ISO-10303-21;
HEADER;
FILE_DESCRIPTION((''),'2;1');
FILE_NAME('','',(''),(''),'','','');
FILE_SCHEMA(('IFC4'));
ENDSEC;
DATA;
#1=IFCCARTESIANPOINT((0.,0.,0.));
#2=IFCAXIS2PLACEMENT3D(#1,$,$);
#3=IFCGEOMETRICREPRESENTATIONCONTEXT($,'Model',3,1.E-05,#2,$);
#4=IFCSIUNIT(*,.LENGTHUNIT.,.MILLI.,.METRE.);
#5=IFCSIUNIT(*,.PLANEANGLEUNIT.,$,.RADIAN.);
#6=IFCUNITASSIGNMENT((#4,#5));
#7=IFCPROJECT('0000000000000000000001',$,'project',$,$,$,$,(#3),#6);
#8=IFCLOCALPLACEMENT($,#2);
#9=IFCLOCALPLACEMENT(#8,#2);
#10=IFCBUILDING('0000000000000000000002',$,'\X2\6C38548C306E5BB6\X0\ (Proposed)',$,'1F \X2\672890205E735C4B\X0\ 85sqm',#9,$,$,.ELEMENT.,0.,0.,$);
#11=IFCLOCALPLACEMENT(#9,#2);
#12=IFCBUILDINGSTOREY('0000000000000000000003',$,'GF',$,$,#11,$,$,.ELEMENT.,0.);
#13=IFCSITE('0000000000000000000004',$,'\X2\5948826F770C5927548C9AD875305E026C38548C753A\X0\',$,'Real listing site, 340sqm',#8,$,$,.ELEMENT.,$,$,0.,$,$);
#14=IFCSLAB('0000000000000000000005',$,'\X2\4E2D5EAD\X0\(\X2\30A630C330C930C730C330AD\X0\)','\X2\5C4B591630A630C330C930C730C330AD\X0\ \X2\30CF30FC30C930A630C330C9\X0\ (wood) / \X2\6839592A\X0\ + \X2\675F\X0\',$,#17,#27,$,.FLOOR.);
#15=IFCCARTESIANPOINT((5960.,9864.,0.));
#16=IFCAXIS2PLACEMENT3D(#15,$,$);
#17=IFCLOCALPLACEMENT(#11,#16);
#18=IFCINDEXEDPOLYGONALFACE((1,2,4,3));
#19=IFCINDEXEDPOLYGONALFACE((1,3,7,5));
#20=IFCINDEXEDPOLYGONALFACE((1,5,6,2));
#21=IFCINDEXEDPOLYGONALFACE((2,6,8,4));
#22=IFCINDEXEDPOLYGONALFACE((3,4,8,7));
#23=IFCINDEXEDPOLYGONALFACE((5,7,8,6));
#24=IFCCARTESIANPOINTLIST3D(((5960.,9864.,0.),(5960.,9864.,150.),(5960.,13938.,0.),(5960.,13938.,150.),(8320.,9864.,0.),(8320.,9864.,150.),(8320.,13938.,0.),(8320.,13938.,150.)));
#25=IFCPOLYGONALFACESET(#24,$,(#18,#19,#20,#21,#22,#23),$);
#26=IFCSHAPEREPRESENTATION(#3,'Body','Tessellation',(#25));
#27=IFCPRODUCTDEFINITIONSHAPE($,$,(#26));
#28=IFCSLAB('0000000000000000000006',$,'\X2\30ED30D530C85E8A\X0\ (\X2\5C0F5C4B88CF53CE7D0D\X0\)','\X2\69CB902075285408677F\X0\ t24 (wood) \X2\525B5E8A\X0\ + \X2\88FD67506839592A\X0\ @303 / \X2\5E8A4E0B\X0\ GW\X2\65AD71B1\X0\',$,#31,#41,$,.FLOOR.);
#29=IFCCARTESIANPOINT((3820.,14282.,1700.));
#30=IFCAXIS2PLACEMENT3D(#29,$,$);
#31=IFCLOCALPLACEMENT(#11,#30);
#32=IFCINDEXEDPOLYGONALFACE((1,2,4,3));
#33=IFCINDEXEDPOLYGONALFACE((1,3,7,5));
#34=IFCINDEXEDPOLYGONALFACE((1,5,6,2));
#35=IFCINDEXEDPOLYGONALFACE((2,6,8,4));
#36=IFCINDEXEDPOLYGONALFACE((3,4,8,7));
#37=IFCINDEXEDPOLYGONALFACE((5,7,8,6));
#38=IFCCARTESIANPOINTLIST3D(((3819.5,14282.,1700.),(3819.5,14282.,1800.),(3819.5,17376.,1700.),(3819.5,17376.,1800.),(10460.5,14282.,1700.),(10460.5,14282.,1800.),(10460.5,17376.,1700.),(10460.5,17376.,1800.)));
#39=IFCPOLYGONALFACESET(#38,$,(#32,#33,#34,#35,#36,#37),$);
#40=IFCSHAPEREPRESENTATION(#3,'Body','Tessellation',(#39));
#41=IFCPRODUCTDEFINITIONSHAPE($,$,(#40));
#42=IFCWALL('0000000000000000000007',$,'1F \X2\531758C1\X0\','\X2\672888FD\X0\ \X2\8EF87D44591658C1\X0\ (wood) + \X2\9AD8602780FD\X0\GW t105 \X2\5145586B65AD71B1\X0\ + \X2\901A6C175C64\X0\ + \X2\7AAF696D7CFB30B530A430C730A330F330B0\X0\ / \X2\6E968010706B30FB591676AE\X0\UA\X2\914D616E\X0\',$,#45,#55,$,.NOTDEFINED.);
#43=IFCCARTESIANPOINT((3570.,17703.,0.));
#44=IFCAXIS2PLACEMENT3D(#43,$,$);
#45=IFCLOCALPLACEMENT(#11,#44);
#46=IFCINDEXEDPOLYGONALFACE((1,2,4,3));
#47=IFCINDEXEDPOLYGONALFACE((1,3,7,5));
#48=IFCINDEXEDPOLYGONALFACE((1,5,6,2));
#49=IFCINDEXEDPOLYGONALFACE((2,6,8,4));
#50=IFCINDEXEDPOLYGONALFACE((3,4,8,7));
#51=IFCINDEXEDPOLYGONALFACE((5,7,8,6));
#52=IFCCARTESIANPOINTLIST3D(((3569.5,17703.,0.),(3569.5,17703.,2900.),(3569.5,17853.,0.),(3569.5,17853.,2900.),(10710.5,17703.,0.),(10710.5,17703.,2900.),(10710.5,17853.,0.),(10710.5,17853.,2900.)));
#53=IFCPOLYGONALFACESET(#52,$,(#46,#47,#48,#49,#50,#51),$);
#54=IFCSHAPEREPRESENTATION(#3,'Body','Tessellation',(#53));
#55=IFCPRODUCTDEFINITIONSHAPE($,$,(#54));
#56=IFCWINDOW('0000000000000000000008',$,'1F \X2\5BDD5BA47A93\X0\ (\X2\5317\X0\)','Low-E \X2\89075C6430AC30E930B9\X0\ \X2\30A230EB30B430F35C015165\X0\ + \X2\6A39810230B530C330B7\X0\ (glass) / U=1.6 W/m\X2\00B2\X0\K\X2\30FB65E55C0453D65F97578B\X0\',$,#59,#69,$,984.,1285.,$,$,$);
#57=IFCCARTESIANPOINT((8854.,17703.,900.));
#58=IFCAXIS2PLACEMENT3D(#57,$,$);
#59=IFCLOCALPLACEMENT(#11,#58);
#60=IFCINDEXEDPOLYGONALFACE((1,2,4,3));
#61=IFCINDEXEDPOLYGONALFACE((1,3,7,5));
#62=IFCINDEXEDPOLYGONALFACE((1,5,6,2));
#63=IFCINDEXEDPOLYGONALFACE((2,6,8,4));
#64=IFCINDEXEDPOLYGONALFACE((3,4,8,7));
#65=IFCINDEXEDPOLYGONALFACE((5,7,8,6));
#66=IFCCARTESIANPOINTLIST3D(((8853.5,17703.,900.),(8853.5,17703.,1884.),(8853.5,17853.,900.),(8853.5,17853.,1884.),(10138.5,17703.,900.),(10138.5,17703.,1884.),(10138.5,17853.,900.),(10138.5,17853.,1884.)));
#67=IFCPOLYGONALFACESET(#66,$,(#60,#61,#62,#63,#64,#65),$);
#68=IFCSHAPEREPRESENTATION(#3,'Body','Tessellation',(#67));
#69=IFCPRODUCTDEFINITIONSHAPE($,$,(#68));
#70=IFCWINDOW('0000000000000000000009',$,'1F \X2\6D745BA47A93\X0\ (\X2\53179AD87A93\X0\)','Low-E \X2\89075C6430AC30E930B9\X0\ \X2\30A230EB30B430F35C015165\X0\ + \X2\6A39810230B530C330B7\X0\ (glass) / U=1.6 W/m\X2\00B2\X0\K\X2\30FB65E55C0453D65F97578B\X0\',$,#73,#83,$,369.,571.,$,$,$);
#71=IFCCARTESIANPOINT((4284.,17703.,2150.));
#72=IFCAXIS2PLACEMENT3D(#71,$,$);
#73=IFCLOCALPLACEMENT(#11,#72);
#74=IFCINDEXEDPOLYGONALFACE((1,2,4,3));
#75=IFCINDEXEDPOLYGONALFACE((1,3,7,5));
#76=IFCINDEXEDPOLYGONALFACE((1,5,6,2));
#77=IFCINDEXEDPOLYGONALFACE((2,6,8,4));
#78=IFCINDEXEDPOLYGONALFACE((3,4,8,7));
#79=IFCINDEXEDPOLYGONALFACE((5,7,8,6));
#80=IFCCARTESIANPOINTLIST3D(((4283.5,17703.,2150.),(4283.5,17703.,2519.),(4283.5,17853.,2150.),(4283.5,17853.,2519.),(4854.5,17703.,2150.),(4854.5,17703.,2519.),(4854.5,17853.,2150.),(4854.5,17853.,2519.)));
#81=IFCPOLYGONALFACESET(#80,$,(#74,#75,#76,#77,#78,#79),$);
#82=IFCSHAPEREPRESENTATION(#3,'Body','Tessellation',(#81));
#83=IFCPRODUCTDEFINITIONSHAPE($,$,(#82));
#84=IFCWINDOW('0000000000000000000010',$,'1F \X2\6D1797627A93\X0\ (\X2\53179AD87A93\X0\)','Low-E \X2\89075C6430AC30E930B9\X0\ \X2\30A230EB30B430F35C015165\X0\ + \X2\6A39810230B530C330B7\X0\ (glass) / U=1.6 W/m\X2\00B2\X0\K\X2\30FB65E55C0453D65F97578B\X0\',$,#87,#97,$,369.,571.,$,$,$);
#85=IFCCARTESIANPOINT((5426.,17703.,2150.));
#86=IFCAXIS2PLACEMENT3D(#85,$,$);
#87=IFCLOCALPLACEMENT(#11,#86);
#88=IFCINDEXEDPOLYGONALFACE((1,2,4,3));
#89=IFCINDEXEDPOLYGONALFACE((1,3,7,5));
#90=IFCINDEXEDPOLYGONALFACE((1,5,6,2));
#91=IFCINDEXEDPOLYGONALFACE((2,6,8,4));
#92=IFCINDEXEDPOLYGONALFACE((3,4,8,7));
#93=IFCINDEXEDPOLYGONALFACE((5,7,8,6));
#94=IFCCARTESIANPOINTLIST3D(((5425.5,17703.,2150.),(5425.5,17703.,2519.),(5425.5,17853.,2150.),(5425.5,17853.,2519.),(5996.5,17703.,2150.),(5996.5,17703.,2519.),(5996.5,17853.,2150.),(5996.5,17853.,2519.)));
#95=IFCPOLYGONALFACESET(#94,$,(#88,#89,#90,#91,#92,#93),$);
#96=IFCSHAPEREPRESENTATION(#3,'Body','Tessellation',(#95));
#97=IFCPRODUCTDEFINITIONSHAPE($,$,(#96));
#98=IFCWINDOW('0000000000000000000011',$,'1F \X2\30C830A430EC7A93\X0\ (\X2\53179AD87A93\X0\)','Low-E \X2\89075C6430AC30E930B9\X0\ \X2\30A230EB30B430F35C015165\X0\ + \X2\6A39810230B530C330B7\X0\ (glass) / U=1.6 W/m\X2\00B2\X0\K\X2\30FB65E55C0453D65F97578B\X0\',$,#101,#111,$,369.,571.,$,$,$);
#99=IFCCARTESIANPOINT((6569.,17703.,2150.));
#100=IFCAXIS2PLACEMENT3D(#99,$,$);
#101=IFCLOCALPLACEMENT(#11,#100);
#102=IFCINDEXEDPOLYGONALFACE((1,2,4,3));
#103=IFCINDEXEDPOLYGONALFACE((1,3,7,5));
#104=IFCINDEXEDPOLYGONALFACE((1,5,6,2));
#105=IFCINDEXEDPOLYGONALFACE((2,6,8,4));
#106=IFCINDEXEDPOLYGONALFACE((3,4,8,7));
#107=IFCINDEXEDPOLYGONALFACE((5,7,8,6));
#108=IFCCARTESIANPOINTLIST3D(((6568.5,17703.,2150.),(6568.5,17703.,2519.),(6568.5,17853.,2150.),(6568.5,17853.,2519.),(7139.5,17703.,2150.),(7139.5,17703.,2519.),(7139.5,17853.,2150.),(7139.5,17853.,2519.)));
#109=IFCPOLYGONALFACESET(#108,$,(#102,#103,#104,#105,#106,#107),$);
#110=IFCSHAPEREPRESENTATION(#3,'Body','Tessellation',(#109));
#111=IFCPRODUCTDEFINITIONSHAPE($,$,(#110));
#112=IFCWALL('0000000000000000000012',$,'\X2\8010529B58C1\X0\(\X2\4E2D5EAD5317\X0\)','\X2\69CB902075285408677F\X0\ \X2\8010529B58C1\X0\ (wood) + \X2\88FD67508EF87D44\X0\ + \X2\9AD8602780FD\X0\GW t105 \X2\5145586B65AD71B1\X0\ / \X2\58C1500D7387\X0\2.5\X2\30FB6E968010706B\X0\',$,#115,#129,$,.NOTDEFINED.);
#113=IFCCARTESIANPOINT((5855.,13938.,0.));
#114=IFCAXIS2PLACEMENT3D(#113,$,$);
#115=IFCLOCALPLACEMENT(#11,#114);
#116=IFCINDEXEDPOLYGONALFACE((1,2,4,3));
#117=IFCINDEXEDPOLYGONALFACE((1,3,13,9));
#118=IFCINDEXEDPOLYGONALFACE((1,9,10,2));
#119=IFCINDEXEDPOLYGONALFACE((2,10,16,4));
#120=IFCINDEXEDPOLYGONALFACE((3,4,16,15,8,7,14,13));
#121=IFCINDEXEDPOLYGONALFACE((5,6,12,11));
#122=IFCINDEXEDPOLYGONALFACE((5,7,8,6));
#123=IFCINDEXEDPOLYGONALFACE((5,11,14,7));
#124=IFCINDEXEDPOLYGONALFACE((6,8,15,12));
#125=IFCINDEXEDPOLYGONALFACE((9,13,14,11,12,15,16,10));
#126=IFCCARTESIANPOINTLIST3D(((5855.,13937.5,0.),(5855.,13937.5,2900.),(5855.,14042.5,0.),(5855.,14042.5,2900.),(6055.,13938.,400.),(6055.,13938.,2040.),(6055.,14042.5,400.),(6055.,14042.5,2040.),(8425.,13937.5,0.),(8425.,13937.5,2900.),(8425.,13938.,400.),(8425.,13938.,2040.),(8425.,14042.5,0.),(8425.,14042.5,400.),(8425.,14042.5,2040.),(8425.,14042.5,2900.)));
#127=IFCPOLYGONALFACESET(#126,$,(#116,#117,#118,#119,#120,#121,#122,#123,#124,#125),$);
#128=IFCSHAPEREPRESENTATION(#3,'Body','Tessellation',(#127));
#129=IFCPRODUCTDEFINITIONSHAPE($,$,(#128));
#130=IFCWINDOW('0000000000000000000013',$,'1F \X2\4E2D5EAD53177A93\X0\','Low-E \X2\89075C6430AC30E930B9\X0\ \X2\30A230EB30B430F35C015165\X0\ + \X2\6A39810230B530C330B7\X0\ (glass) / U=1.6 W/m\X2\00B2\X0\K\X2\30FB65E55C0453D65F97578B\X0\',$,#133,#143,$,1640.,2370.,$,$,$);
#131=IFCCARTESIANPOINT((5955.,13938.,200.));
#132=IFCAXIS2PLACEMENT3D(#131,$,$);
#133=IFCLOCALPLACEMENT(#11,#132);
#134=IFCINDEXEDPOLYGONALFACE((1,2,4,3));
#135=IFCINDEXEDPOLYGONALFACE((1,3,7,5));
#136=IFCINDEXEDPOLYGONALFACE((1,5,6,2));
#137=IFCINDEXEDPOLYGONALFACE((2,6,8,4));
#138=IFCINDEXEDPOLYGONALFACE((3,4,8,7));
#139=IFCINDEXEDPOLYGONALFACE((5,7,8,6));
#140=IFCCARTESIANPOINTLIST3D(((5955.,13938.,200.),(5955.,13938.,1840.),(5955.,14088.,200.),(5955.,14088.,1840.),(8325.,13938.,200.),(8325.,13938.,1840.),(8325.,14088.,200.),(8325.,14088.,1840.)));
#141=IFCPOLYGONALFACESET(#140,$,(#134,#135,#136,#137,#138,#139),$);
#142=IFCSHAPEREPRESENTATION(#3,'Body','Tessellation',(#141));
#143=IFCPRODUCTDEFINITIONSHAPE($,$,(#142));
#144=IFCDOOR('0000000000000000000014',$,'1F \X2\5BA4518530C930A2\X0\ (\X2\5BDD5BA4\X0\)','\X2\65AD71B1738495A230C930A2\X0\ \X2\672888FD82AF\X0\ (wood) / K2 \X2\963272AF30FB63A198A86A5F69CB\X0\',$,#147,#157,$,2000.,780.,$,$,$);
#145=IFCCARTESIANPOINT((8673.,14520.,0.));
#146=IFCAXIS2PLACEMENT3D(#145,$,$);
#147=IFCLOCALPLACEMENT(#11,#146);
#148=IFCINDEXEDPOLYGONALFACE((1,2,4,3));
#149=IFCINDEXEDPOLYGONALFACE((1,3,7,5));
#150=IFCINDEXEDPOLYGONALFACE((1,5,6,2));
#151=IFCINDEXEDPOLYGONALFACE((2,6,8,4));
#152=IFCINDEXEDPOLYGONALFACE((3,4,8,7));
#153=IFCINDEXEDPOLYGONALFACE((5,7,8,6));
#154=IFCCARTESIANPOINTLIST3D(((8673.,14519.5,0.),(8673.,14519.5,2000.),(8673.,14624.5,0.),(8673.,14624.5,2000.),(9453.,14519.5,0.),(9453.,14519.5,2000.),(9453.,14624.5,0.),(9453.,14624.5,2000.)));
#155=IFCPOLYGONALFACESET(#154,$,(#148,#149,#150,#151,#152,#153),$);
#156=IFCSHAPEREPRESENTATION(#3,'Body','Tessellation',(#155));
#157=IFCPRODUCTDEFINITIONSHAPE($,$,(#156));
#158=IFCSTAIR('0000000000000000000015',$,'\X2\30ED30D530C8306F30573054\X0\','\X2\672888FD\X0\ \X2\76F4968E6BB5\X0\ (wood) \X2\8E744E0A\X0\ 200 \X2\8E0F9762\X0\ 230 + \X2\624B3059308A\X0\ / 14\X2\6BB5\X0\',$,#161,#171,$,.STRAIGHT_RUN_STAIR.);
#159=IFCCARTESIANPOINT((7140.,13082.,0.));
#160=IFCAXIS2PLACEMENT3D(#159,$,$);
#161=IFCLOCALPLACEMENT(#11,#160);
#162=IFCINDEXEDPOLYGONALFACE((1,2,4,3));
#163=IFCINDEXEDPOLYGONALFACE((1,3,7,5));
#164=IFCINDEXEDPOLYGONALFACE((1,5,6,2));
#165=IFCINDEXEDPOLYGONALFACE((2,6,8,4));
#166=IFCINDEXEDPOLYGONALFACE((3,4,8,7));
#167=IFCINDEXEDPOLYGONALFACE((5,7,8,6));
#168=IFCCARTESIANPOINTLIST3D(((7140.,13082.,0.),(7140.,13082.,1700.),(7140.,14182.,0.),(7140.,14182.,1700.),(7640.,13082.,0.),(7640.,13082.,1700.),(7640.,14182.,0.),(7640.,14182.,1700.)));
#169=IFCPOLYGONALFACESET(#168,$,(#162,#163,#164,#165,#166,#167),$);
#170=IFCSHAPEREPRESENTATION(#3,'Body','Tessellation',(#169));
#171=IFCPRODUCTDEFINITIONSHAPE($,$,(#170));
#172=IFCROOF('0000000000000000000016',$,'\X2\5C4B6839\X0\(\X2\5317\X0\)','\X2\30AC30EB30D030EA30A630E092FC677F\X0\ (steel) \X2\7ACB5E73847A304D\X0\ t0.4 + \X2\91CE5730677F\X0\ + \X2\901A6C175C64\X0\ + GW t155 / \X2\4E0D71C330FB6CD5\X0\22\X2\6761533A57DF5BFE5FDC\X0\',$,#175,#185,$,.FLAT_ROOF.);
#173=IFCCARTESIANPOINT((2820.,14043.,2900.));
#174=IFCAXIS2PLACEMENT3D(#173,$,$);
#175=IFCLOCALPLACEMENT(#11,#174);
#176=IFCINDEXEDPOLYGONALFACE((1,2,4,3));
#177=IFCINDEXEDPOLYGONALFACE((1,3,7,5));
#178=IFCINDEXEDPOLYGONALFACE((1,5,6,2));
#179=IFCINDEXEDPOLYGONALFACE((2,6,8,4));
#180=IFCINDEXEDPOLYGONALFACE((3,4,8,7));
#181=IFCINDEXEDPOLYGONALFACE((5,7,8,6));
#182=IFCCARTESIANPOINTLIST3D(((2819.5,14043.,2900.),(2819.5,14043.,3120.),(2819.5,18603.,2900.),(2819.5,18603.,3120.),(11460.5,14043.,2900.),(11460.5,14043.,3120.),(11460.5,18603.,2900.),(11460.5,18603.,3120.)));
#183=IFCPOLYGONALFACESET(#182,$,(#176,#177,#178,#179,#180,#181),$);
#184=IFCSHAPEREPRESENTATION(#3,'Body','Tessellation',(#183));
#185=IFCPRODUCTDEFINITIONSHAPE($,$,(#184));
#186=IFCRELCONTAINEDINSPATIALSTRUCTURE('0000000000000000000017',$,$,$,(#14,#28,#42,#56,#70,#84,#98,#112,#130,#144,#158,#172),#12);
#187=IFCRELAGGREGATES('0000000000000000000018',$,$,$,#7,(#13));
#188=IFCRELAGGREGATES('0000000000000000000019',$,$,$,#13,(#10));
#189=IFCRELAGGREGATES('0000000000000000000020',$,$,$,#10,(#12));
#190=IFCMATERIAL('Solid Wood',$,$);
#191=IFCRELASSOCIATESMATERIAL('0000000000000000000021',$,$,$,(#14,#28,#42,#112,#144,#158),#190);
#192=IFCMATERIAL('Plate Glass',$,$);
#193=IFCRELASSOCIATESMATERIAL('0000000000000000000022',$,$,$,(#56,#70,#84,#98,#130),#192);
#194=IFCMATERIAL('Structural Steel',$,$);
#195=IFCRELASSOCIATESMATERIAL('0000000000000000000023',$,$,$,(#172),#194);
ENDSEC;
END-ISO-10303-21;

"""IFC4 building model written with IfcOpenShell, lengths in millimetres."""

from ifc_helpers import new_model, si_unit, frame, frame_2d, origin, place, context, project, spatial, rectangle, extrude, material, element, fill, save


model = new_model("IFC4")

# Units and contexts
model_context = context("Model", 3, precision=1e-05, world=origin())
ifc_project = project(units=[si_unit("LENGTHUNIT", "METRE", prefix="MILLI"), si_unit("PLANEANGLEUNIT", "RADIAN")], contexts=[model_context])

# Site, building, storey
site_placement = place(None, origin())
site = spatial("IfcSite", under=ifc_project, at=site_placement, Name="奈良県大和高田市永和町", ObjectType="Real listing site, 340sqm", CompositionType="ELEMENT", RefElevation=0.0)
building_placement = place(site_placement, origin())
building = spatial("IfcBuilding", under=site, at=building_placement, Name="永和の家 (Proposed)", ObjectType="1F 木造平屋 85sqm", CompositionType="ELEMENT", ElevationOfRefHeight=0.0, ElevationOfTerrain=0.0)
storey_placement = place(building_placement, origin())
storey = spatial("IfcBuildingStorey", under=building, at=storey_placement, Name="GF", CompositionType="ELEMENT", Elevation=0.0)

# Slabs
ifc_material_1 = material(Name="Solid Wood")
slab_1_placement = place(storey_placement, frame((5960.0, 9864.0, 0.0)))
element("IfcSlab", 1, at=slab_1_placement, inside=storey, material=ifc_material_1, Name="中庭(ウッドデッキ)", Description="屋外ウッドデッキ ハードウッド (wood) / 根太 + 束", PredefinedType="FLOOR", context=model_context, shape_type="SweptSolid", body=[
    extrude(rectangle(XDim=2360.0, YDim=4074.0, at=frame_2d((1180.0, 2037.0))), frame((5960.0, 9864.0, 0.0)), (0.0, 0.0, 1.0), 150.0),
])
slab_2_placement = place(storey_placement, frame((3820.0, 14282.0, 1700.0)))
element("IfcSlab", 2, at=slab_2_placement, inside=storey, material=ifc_material_1, Name="ロフト床 (小屋裏収納)", Description="構造用合板 t24 (wood) 剛床 + 製材根太 @303 / 床下 GW断熱", PredefinedType="FLOOR", context=model_context, shape_type="SweptSolid", body=[
    extrude(rectangle(XDim=6641.0, YDim=3094.0, at=frame_2d((3320.0, 1547.0))), frame((3820.0, 14282.0, 1700.0)), (0.0, 0.0, 1.0), 100.0),
])

# Wall, openings, windows
wall_1_placement = place(storey_placement, frame((3570.0, 17703.0, 0.0)))
wall_1 = element("IfcWall", 3, at=wall_1_placement, inside=storey, material=ifc_material_1, Name="1F 北壁", Description="木製 軸組外壁 (wood) + 高性能GW t105 充填断熱 + 通気層 + 窯業系サイディング / 準耐火・外皮UA配慮", PredefinedType="NOTDEFINED", context=model_context, shape_type="SweptSolid", body=[
    extrude(rectangle(XDim=7141.0, YDim=150.0, at=frame_2d((3570.0, 75.0))), frame((3570.0, 17703.0, 0.0)), (0.0, 0.0, 1.0), 2900.0),
])
opening_1_placement = place(storey_placement, frame((8854.0, 17703.0, 900.0)))
opening_1 = element("IfcOpeningElement", 4, at=opening_1_placement, cuts=wall_1, PredefinedType="NOTDEFINED", context=model_context, shape_type="SweptSolid", body=[
    extrude(rectangle(XDim=1285.0, YDim=150.0, at=frame_2d((642.0, 75.0))), frame((8854.0, 17703.0, 900.0)), (0.0, 0.0, 1.0), 984.0),
])
opening_2_placement = place(storey_placement, frame((4284.0, 17703.0, 2150.0)))
opening_2 = element("IfcOpeningElement", 5, at=opening_2_placement, cuts=wall_1, PredefinedType="NOTDEFINED", context=model_context, shape_type="SweptSolid", body=[
    extrude(rectangle(XDim=571.0, YDim=150.0, at=frame_2d((285.0, 75.0))), frame((4284.0, 17703.0, 2150.0)), (0.0, 0.0, 1.0), 369.0),
])
opening_3_placement = place(storey_placement, frame((5426.0, 17703.0, 2150.0)))
opening_3 = element("IfcOpeningElement", 6, at=opening_3_placement, cuts=wall_1, PredefinedType="NOTDEFINED", context=model_context, shape_type="SweptSolid", body=[
    extrude(rectangle(XDim=571.0, YDim=150.0, at=frame_2d((285.0, 75.0))), frame((5426.0, 17703.0, 2150.0)), (0.0, 0.0, 1.0), 369.0),
])
opening_4_placement = place(storey_placement, frame((6569.0, 17703.0, 2150.0)))
opening_4 = element("IfcOpeningElement", 7, at=opening_4_placement, cuts=wall_1, PredefinedType="NOTDEFINED", context=model_context, shape_type="SweptSolid", body=[
    extrude(rectangle(XDim=571.0, YDim=150.0, at=frame_2d((285.0, 75.0))), frame((6569.0, 17703.0, 2150.0)), (0.0, 0.0, 1.0), 369.0),
])
ifc_material_2 = material(Name="Plate Glass")
window_1_placement = place(storey_placement, frame((8854.0, 17703.0, 900.0)))
window_1 = element("IfcWindow", 8, at=window_1_placement, inside=storey, material=ifc_material_2, Name="1F 寝室窓 (北)", Description="Low-E 複層ガラス アルゴン封入 + 樹脂サッシ (glass) / U=1.6 W/m²K・日射取得型", OverallHeight=984.0, OverallWidth=1285.0, context=model_context, shape_type="SweptSolid", body=[
    extrude(rectangle(XDim=1285.0, YDim=150.0, at=frame_2d((642.0, 75.0))), frame((8854.0, 17703.0, 900.0)), (0.0, 0.0, 1.0), 984.0),
])
fill(opening_1, window_1)
window_2_placement = place(storey_placement, frame((4284.0, 17703.0, 2150.0)))
window_2 = element("IfcWindow", 9, at=window_2_placement, inside=storey, material=ifc_material_2, Name="1F 浴室窓 (北高窓)", Description="Low-E 複層ガラス アルゴン封入 + 樹脂サッシ (glass) / U=1.6 W/m²K・日射取得型", OverallHeight=369.0, OverallWidth=571.0, context=model_context, shape_type="SweptSolid", body=[
    extrude(rectangle(XDim=571.0, YDim=150.0, at=frame_2d((285.0, 75.0))), frame((4284.0, 17703.0, 2150.0)), (0.0, 0.0, 1.0), 369.0),
])
fill(opening_2, window_2)
window_3_placement = place(storey_placement, frame((5426.0, 17703.0, 2150.0)))
window_3 = element("IfcWindow", 10, at=window_3_placement, inside=storey, material=ifc_material_2, Name="1F 洗面窓 (北高窓)", Description="Low-E 複層ガラス アルゴン封入 + 樹脂サッシ (glass) / U=1.6 W/m²K・日射取得型", OverallHeight=369.0, OverallWidth=571.0, context=model_context, shape_type="SweptSolid", body=[
    extrude(rectangle(XDim=571.0, YDim=150.0, at=frame_2d((285.0, 75.0))), frame((5426.0, 17703.0, 2150.0)), (0.0, 0.0, 1.0), 369.0),
])
fill(opening_3, window_3)
window_4_placement = place(storey_placement, frame((6569.0, 17703.0, 2150.0)))
window_4 = element("IfcWindow", 11, at=window_4_placement, inside=storey, material=ifc_material_2, Name="1F トイレ窓 (北高窓)", Description="Low-E 複層ガラス アルゴン封入 + 樹脂サッシ (glass) / U=1.6 W/m²K・日射取得型", OverallHeight=369.0, OverallWidth=571.0, context=model_context, shape_type="SweptSolid", body=[
    extrude(rectangle(XDim=571.0, YDim=150.0, at=frame_2d((285.0, 75.0))), frame((6569.0, 17703.0, 2150.0)), (0.0, 0.0, 1.0), 369.0),
])
fill(opening_4, window_4)

# Wall, opening, window
wall_2_placement = place(storey_placement, frame((5855.0, 13938.0, 0.0)))
wall_2 = element("IfcWall", 12, at=wall_2_placement, inside=storey, material=ifc_material_1, Name="耐力壁(中庭北)", Description="構造用合板 耐力壁 (wood) + 製材軸組 + 高性能GW t105 充填断熱 / 壁倍率2.5・準耐火", PredefinedType="NOTDEFINED", context=model_context, shape_type="SweptSolid", body=[
    extrude(rectangle(XDim=2570.0, YDim=105.0, at=frame_2d((1285.0, 52.0))), frame((5855.0, 13938.0, 0.0)), (0.0, 0.0, 1.0), 2900.0),
])
opening_5_placement = place(storey_placement, frame((5955.0, 13938.0, 200.0)))
opening_5 = element("IfcOpeningElement", 13, at=opening_5_placement, cuts=wall_2, PredefinedType="NOTDEFINED", context=model_context, shape_type="SweptSolid", body=[
    extrude(rectangle(XDim=2370.0, YDim=150.0, at=frame_2d((1185.0, 75.0))), frame((5955.0, 13938.0, 200.0)), (0.0, 0.0, 1.0), 1640.0),
])
window_5_placement = place(storey_placement, frame((5955.0, 13938.0, 200.0)))
window_5 = element("IfcWindow", 14, at=window_5_placement, inside=storey, material=ifc_material_2, Name="1F 中庭北窓", Description="Low-E 複層ガラス アルゴン封入 + 樹脂サッシ (glass) / U=1.6 W/m²K・日射取得型", OverallHeight=1640.0, OverallWidth=2370.0, context=model_context, shape_type="SweptSolid", body=[
    extrude(rectangle(XDim=2370.0, YDim=150.0, at=frame_2d((1185.0, 75.0))), frame((5955.0, 13938.0, 200.0)), (0.0, 0.0, 1.0), 1640.0),
])
fill(opening_5, window_5)

# Door
door_1_placement = place(storey_placement, frame((8673.0, 14520.0, 0.0)))
element("IfcDoor", 15, at=door_1_placement, inside=storey, material=ifc_material_1, Name="1F 室内ドア (寝室)", Description="断熱玄関ドア 木製芯 (wood) / K2 防犯・採風機構", OverallHeight=2000.0, OverallWidth=780.0, context=model_context, shape_type="SweptSolid", body=[
    extrude(rectangle(XDim=780.0, YDim=105.0, at=frame_2d((390.0, 52.0))), frame((8673.0, 14520.0, 0.0)), (0.0, 0.0, 1.0), 2000.0),
])

# Stair
stair_placement = place(storey_placement, frame((7140.0, 13082.0, 0.0)))
element("IfcStair", 16, at=stair_placement, inside=storey, material=ifc_material_1, Name="ロフトはしご", Description="木製 直階段 (wood) 蹴上 200 踏面 230 + 手すり / 14段", PredefinedType="STRAIGHT_RUN_STAIR", context=model_context, shape_type="SweptSolid", body=[
    extrude(rectangle(XDim=500.0, YDim=1100.0, at=frame_2d((250.0, 550.0))), frame((7140.0, 13082.0, 0.0)), (0.0, 0.0, 1.0), 1700.0),
])

# Roof
ifc_material_3 = material(Name="Structural Steel")
roof_1_placement = place(storey_placement, frame((2820.0, 14043.0, 2900.0)))
element("IfcRoof", 17, at=roof_1_placement, inside=storey, material=ifc_material_3, Name="屋根(北)", Description="ガルバリウム鋼板 (steel) 立平葺き t0.4 + 野地板 + 通気層 + GW t155 / 不燃・法22条区域対応", PredefinedType="FLAT_ROOF", context=model_context, shape_type="SweptSolid", body=[
    extrude(rectangle(XDim=8641.0, YDim=4560.0, at=frame_2d((4320.0, 2280.0))), frame((2820.0, 14043.0, 2900.0)), (0.0, 0.0, 1.0), 220.0),
])

save(model, "model.ifc")
